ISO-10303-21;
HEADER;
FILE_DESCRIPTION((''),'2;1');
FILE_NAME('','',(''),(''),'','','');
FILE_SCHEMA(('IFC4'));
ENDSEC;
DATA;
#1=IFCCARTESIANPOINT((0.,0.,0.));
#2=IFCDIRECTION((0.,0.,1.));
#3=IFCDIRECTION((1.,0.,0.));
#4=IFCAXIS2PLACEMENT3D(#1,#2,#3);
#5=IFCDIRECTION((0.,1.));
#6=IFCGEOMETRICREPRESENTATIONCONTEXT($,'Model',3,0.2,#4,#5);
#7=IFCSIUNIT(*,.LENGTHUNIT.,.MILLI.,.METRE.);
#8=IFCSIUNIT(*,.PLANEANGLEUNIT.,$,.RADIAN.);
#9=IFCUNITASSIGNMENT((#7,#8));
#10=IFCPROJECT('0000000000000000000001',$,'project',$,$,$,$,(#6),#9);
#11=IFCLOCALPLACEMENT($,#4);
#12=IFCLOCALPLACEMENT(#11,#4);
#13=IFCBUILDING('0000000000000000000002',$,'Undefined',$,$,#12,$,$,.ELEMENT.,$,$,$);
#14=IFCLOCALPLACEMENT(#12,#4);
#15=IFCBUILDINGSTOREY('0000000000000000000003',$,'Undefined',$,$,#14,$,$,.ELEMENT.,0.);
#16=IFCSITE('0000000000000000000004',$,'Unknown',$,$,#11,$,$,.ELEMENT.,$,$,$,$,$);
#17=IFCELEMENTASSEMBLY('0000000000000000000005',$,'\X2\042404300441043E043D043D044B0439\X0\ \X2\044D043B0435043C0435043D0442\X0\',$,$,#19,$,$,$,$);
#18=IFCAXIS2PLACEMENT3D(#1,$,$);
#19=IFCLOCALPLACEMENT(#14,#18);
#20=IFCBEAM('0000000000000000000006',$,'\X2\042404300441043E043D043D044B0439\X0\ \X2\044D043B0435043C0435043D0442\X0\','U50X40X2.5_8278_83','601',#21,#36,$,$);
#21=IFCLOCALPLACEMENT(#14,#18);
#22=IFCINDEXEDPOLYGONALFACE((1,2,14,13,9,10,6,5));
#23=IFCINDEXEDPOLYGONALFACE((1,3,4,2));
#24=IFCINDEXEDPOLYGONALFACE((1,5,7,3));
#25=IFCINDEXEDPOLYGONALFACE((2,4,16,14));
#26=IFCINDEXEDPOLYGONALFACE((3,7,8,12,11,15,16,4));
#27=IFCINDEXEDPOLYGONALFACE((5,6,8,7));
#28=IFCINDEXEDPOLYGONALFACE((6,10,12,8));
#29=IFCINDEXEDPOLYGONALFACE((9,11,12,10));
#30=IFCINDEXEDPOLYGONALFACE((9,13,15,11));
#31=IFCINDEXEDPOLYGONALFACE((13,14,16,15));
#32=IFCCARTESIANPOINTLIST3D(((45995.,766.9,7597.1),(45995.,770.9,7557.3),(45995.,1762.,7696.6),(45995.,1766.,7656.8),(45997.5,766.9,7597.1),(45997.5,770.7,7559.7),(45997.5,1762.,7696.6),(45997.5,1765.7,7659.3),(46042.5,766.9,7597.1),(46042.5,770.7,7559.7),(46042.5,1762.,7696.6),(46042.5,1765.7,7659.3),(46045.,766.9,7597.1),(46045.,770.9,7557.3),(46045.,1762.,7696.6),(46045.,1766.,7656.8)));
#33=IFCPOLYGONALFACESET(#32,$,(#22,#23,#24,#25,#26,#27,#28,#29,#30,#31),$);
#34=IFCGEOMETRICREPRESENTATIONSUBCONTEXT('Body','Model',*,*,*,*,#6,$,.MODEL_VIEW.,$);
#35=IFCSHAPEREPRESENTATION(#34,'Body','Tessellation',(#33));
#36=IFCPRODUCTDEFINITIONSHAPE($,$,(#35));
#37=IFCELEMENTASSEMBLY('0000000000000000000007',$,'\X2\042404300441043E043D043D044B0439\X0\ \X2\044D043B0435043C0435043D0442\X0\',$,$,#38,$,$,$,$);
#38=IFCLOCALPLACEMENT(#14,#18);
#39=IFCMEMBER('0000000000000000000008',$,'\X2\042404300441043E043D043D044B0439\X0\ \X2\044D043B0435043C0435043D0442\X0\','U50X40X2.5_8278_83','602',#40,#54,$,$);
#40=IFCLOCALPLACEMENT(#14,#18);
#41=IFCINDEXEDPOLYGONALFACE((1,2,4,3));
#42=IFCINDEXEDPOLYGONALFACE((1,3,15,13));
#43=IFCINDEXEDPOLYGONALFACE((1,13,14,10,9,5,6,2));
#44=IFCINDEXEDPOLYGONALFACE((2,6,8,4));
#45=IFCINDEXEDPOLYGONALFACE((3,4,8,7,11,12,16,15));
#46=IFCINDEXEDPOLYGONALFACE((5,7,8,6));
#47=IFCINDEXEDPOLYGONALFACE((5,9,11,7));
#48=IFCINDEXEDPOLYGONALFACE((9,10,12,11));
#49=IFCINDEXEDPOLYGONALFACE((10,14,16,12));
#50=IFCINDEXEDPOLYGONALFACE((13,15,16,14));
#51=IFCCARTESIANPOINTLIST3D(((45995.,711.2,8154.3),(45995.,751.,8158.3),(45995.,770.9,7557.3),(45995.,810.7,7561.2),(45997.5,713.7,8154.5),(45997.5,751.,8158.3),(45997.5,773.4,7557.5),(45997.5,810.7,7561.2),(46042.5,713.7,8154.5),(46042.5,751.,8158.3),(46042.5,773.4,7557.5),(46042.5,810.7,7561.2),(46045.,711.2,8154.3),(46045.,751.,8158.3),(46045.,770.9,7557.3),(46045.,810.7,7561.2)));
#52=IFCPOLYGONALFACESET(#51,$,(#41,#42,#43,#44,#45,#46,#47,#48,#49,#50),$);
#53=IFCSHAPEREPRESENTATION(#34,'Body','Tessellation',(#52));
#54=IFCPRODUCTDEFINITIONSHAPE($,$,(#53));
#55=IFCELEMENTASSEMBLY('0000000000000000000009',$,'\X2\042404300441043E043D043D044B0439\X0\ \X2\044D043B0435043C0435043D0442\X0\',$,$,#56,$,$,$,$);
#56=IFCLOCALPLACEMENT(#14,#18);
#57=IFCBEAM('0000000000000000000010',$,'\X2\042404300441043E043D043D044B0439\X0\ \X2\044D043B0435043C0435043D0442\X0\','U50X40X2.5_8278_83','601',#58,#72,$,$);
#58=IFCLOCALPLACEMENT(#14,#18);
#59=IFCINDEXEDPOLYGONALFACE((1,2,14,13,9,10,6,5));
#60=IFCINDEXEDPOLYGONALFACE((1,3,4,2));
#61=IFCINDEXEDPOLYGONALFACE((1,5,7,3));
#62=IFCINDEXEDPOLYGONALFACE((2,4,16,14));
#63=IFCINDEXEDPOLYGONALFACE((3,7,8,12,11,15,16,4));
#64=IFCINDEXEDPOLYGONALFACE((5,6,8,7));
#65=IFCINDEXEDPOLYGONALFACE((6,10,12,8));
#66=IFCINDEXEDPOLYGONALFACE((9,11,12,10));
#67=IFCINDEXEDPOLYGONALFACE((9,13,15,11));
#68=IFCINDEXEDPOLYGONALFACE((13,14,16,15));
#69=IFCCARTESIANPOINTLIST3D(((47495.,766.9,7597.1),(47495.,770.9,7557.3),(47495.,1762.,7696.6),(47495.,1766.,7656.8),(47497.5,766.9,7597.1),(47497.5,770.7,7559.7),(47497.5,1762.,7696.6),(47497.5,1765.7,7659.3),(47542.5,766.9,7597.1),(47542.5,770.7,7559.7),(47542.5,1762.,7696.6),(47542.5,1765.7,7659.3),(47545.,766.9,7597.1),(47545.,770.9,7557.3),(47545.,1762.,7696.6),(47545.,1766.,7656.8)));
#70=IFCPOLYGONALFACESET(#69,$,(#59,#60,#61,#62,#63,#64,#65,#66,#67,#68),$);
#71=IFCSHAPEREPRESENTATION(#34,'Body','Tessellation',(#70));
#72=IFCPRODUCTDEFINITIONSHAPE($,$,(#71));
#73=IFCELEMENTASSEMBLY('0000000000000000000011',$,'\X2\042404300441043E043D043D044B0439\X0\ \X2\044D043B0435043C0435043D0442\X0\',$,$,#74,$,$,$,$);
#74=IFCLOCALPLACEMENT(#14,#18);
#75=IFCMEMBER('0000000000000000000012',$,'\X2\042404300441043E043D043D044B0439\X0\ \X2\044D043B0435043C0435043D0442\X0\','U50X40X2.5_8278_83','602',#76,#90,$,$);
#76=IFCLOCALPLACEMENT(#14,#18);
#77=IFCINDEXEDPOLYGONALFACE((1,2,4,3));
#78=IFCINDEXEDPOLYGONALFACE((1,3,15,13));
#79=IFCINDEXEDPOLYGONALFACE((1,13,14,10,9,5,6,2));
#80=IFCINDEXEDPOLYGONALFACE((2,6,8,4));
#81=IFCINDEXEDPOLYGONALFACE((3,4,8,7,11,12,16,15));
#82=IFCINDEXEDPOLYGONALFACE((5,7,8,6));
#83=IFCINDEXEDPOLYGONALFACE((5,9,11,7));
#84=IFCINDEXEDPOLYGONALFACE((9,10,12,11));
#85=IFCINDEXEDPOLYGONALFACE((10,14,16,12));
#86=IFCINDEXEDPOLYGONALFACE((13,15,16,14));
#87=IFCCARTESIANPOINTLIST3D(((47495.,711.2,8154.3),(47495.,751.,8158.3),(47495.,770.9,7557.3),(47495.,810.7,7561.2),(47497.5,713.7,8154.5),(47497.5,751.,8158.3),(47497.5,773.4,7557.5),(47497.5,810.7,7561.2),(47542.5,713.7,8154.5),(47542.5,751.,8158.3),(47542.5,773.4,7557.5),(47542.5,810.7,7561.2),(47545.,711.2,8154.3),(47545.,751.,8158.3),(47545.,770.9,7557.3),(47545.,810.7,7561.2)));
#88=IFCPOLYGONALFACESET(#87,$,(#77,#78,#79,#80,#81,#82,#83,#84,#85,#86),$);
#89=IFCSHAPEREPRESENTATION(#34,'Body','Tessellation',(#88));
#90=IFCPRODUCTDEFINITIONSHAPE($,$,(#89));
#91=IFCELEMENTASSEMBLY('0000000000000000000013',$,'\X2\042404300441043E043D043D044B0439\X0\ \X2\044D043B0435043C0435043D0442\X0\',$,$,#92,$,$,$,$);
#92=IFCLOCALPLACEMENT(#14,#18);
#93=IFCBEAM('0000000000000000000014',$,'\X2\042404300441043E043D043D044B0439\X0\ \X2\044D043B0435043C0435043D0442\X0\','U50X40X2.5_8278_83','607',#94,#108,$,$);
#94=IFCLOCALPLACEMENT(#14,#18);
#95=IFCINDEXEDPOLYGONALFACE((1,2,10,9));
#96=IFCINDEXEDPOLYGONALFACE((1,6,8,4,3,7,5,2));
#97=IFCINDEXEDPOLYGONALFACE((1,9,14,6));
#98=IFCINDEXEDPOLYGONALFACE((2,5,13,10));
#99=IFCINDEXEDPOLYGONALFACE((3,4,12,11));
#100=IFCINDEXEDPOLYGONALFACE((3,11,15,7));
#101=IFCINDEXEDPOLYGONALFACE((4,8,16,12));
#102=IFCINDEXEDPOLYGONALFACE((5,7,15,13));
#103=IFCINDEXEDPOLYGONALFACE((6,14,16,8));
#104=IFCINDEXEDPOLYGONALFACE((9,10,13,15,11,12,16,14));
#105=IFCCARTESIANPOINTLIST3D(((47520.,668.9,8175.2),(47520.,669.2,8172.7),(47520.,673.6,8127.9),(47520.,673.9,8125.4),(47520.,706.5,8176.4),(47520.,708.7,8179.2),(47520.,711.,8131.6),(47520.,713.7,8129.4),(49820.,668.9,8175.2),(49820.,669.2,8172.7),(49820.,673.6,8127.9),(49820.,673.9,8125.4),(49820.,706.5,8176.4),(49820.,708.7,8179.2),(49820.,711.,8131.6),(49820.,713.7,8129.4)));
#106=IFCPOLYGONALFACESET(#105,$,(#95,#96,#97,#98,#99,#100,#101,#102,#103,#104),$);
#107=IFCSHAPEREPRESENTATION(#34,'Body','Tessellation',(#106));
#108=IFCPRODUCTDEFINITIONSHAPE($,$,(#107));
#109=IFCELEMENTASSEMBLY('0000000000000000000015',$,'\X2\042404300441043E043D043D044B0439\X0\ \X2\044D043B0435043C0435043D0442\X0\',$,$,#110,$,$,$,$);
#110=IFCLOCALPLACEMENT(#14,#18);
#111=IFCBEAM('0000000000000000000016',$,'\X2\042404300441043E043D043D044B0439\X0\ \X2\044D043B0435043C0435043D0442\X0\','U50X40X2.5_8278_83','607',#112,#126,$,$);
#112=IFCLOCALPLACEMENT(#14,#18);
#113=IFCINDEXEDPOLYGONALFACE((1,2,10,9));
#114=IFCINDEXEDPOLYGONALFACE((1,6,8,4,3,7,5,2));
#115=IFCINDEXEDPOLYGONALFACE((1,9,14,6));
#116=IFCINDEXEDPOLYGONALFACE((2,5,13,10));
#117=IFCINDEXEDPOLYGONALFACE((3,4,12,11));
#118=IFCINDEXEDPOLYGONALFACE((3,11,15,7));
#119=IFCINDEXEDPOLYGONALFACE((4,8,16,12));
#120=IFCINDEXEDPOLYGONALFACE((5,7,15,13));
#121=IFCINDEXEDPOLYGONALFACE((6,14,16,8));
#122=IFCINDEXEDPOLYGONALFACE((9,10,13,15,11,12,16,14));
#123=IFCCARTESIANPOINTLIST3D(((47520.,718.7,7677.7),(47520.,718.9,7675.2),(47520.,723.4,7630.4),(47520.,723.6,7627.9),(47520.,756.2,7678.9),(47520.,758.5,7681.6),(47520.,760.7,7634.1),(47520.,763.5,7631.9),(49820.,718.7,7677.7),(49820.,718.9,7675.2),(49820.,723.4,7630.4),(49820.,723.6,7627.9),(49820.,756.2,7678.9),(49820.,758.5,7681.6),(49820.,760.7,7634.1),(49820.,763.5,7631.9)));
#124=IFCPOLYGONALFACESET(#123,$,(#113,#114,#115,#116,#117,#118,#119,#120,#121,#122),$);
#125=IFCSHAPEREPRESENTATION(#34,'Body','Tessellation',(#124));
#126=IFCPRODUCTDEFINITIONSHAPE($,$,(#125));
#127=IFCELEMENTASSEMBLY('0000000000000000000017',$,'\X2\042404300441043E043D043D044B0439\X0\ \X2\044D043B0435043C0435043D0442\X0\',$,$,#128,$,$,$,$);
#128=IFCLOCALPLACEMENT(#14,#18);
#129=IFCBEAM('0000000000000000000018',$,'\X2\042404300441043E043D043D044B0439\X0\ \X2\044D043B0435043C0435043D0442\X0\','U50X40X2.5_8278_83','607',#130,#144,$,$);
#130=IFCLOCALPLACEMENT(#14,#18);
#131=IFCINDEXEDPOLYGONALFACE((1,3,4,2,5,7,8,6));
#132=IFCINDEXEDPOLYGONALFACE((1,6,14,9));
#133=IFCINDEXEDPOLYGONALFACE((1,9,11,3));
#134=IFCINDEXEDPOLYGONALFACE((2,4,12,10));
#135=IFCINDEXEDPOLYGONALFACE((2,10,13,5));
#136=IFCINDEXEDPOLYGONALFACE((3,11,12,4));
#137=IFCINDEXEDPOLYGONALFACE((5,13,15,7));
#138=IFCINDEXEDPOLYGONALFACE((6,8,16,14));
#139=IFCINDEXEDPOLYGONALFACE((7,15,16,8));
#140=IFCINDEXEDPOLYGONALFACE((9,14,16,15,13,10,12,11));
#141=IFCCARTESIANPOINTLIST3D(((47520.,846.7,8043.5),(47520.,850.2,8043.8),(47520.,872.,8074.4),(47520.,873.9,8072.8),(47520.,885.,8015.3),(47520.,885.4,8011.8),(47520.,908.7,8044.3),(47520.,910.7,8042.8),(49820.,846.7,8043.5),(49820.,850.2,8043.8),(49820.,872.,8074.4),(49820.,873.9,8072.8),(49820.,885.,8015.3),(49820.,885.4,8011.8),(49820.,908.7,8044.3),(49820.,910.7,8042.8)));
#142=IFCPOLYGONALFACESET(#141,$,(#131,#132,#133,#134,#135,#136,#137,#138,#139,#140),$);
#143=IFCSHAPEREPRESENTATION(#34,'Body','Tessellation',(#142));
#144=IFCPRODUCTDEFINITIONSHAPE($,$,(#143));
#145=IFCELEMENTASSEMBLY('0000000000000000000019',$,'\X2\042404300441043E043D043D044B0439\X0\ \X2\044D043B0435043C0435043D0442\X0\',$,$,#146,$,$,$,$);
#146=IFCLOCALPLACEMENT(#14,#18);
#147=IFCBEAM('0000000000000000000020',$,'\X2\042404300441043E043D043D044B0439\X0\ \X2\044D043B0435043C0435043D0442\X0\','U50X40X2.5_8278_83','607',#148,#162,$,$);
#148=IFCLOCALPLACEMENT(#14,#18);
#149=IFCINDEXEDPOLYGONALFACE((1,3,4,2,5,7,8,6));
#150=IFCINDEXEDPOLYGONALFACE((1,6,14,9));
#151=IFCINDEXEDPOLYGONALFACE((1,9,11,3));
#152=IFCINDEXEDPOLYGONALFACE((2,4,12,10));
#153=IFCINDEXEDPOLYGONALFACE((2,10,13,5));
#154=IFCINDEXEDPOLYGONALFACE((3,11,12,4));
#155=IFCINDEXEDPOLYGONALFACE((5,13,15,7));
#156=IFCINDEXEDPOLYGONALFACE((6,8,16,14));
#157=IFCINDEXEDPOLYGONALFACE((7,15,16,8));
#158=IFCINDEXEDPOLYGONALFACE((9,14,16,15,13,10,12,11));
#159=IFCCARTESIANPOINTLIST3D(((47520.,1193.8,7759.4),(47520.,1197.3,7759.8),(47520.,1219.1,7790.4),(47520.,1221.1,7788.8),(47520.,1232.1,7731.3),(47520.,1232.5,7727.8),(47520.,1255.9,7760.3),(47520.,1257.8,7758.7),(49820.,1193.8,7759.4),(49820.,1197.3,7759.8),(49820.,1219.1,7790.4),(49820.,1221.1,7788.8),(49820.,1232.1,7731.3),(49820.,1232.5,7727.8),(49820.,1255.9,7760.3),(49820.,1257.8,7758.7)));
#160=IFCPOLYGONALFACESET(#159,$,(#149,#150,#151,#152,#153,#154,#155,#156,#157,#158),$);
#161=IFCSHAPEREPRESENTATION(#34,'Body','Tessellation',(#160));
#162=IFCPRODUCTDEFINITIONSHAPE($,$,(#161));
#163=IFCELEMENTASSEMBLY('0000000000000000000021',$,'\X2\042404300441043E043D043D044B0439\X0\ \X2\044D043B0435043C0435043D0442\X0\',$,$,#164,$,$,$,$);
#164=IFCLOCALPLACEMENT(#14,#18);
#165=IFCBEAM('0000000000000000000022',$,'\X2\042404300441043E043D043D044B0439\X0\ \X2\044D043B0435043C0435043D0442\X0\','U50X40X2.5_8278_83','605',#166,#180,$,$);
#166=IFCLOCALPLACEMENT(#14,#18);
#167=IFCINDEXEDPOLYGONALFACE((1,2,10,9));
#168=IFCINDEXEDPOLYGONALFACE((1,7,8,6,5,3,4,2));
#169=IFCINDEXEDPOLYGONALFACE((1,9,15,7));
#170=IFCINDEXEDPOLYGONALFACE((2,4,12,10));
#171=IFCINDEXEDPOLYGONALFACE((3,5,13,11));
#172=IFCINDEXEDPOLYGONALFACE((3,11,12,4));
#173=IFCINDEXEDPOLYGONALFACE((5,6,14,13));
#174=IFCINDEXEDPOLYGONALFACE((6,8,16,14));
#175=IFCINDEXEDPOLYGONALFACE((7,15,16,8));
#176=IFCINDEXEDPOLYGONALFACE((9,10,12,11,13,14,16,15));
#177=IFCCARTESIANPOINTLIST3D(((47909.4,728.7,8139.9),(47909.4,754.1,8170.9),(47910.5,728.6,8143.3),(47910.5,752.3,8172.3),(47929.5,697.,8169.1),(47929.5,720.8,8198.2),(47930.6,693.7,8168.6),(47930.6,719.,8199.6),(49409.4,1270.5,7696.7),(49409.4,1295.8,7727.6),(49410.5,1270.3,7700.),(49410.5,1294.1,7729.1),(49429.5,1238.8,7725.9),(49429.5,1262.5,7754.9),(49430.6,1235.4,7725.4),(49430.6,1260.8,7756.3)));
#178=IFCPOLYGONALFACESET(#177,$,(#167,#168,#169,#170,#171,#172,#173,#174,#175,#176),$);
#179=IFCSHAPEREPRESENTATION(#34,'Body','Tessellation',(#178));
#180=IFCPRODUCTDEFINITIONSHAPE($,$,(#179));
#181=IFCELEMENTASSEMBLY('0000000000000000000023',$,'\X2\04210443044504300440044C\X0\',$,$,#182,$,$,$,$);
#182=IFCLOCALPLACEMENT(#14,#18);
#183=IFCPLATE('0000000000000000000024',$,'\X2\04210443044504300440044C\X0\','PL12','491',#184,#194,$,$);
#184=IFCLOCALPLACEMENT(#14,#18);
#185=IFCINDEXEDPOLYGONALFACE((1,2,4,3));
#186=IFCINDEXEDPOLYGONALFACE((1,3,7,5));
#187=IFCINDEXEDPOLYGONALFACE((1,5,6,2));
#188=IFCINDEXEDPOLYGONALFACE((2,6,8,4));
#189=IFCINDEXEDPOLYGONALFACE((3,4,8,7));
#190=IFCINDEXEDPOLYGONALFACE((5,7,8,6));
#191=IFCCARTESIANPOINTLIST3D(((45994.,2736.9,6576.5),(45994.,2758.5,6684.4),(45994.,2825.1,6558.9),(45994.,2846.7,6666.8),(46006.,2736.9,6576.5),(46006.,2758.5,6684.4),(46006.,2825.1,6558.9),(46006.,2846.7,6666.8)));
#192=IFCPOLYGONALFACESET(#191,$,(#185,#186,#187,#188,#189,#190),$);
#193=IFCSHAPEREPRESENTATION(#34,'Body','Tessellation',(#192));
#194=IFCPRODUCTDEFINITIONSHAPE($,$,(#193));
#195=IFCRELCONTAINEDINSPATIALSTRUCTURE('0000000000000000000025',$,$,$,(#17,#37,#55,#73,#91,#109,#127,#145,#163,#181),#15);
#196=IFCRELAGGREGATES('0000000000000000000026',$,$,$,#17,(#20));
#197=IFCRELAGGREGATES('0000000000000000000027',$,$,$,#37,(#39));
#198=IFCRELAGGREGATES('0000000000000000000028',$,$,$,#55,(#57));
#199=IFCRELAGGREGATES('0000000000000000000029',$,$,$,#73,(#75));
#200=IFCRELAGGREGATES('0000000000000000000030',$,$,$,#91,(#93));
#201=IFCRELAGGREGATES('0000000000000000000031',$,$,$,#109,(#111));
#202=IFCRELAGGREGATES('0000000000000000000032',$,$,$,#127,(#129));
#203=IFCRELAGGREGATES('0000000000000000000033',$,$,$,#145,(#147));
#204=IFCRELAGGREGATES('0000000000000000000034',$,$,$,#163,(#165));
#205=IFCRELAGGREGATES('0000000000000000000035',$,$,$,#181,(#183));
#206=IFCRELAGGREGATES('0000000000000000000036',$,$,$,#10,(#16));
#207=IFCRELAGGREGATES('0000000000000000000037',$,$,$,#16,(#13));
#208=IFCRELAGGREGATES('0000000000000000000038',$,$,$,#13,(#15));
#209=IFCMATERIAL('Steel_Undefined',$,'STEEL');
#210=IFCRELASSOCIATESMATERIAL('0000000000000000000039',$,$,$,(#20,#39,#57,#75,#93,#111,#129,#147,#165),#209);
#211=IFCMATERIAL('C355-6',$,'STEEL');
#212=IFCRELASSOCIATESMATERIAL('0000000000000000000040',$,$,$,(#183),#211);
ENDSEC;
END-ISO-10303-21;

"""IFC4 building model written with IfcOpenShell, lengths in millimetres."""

from ifc_helpers import new_model, si_unit, direction, frame, origin_with_axes, place, context, subcontext, project, spatial, line, indexed_curve, outline, extrude, material, element, aggregate, save


model = new_model("IFC4")

# Units and contexts
model_context = context("Model", 3, precision=0.2, world=origin_with_axes(), true_north=direction((0.0, 1.0)))
body_context = subcontext(model_context, "Body", "Model", "MODEL_VIEW")
ifc_project = project(units=[si_unit("LENGTHUNIT", "METRE", prefix="MILLI"), si_unit("PLANEANGLEUNIT", "RADIAN")], contexts=[model_context])

# Site, building, storey
site_placement = place(None, origin_with_axes())
site = spatial("IfcSite", under=ifc_project, at=site_placement, Name="Unknown", CompositionType="ELEMENT")
building_placement = place(site_placement, origin_with_axes())
building = spatial("IfcBuilding", under=site, at=building_placement, Name="Undefined", CompositionType="ELEMENT")
storey_placement = place(building_placement, origin_with_axes())
storey = spatial("IfcBuildingStorey", under=building, at=storey_placement, Name="Undefined", CompositionType="ELEMENT", Elevation=0.0)

# Element assembly, beam
assembly_1_placement = place(storey_placement, frame((46020.0, 768.9, 7577.2), z_axis=(0.0, -0.099504, 0.995037), x_axis=(0.0, 0.995037, 0.099504)))
assembly_1 = element("IfcElementAssembly", 1, at=assembly_1_placement, inside=storey, Name="Фасонный элемент")
ifc_material_1 = material(Name="Steel_Undefined", Category="STEEL")
beam_1_placement = place(assembly_1_placement, origin_with_axes())
beam_1 = element("IfcBeam", 2, at=beam_1_placement, material=ifc_material_1, Name="Фасонный элемент", Description="U50X40X2.5_8278_83", ObjectType="601", context=body_context, shape_type="SolidModel", body=[
    extrude(outline(indexed_curve([(-20.0, -25.0), (20.0, -25.0), (20.0, -22.5), (-17.5, -22.5), (-17.5, 22.5), (20.0, 22.5), (20.0, 25.0), (-20.0, 25.0)], segments=[line(1, 2, 3, 4, 5, 6, 7, 8, 1)])), frame((0.0, 0.0, 0.0), z_axis=(-1.0, 0.0, 0.0), x_axis=(0.0, 0.0, 1.0)), (0.0, 0.0, -1.0), 1000.0),
])
aggregate(assembly_1, [beam_1])

# Element assembly, member
assembly_2_placement = place(storey_placement, frame((46020.0, 790.8, 7559.3), z_axis=(0.0, 0.995037, 0.099504), x_axis=(0.0, -0.099504, 0.995037)))
assembly_2 = element("IfcElementAssembly", 3, at=assembly_2_placement, inside=storey, Name="Фасонный элемент")
member_1_placement = place(assembly_2_placement, origin_with_axes())
member_1 = element("IfcMember", 4, at=member_1_placement, material=ifc_material_1, Name="Фасонный элемент", Description="U50X40X2.5_8278_83", ObjectType="602", context=body_context, shape_type="SolidModel", body=[
    extrude(outline(indexed_curve([(-20.0, -25.0), (20.0, -25.0), (20.0, -22.5), (-17.5, -22.5), (-17.5, 22.5), (20.0, 22.5), (20.0, 25.0), (-20.0, 25.0)], segments=[line(1, 2, 3, 4, 5, 6, 7, 8, 1)])), frame((0.0, 0.0, 0.0), z_axis=(-1.0, 0.0, 0.0), x_axis=(0.0, 0.0, 1.0)), (0.0, 0.0, -1.0), 600.0),
])
aggregate(assembly_2, [member_1])

# Element assembly, beam
assembly_3_placement = place(storey_placement, frame((47520.0, 768.9, 7577.2), z_axis=(0.0, -0.099504, 0.995037), x_axis=(0.0, 0.995037, 0.099504)))
assembly_3 = element("IfcElementAssembly", 5, at=assembly_3_placement, inside=storey, Name="Фасонный элемент")
beam_2_placement = place(assembly_3_placement, origin_with_axes())
beam_2 = element("IfcBeam", 6, at=beam_2_placement, material=ifc_material_1, Name="Фасонный элемент", Description="U50X40X2.5_8278_83", ObjectType="601", context=body_context, shape_type="SolidModel", body=[
    extrude(outline(indexed_curve([(-20.0, -25.0), (20.0, -25.0), (20.0, -22.5), (-17.5, -22.5), (-17.5, 22.5), (20.0, 22.5), (20.0, 25.0), (-20.0, 25.0)], segments=[line(1, 2, 3, 4, 5, 6, 7, 8, 1)])), frame((0.0, 0.0, 0.0), z_axis=(-1.0, 0.0, 0.0), x_axis=(0.0, 0.0, 1.0)), (0.0, 0.0, -1.0), 1000.0),
])
aggregate(assembly_3, [beam_2])

# Element assembly, member
assembly_4_placement = place(storey_placement, frame((47520.0, 790.8, 7559.3), z_axis=(0.0, 0.995037, 0.099504), x_axis=(0.0, -0.099504, 0.995037)))
assembly_4 = element("IfcElementAssembly", 7, at=assembly_4_placement, inside=storey, Name="Фасонный элемент")
member_2_placement = place(assembly_4_placement, origin_with_axes())
member_2 = element("IfcMember", 8, at=member_2_placement, material=ifc_material_1, Name="Фасонный элемент", Description="U50X40X2.5_8278_83", ObjectType="602", context=body_context, shape_type="SolidModel", body=[
    extrude(outline(indexed_curve([(-20.0, -25.0), (20.0, -25.0), (20.0, -22.5), (-17.5, -22.5), (-17.5, 22.5), (20.0, 22.5), (20.0, 25.0), (-20.0, 25.0)], segments=[line(1, 2, 3, 4, 5, 6, 7, 8, 1)])), frame((0.0, 0.0, 0.0), z_axis=(-1.0, 0.0, 0.0), x_axis=(0.0, 0.0, 1.0)), (0.0, 0.0, -1.0), 600.0),
])
aggregate(assembly_4, [member_2])

# Element assemblies, beams
assembly_5_placement = place(storey_placement, frame((47520.0, 691.3, 8152.3), z_axis=(0.0, -0.995037, -0.099504), x_axis=(1.0, 0.0, 0.0)))
assembly_5 = element("IfcElementAssembly", 9, at=assembly_5_placement, inside=storey, Name="Фасонный элемент")
beam_3_placement = place(assembly_5_placement, origin_with_axes())
beam_3 = element("IfcBeam", 10, at=beam_3_placement, material=ifc_material_1, Name="Фасонный элемент", Description="U50X40X2.5_8278_83", ObjectType="607", context=body_context, shape_type="SolidModel", body=[
    extrude(outline(indexed_curve([(-20.0, -25.0), (20.0, -25.0), (20.0, -22.5), (-17.5, -22.5), (-17.5, 22.5), (20.0, 22.5), (20.0, 25.0), (-20.0, 25.0)], segments=[line(1, 2, 3, 4, 5, 6, 7, 8, 1)])), frame((0.0, 0.0, 0.0), z_axis=(-1.0, 0.0, 0.0), x_axis=(0.0, 0.0, 1.0)), (0.0, 0.0, -1.0), 2300.0),
])
aggregate(assembly_5, [beam_3])
assembly_6_placement = place(storey_placement, frame((47520.0, 741.1, 7654.8), z_axis=(0.0, -0.995037, -0.099504), x_axis=(1.0, 0.0, 0.0)))
assembly_6 = element("IfcElementAssembly", 11, at=assembly_6_placement, inside=storey, Name="Фасонный элемент")
beam_4_placement = place(assembly_6_placement, origin_with_axes())
beam_4 = element("IfcBeam", 12, at=beam_4_placement, material=ifc_material_1, Name="Фасонный элемент", Description="U50X40X2.5_8278_83", ObjectType="607", context=body_context, shape_type="SolidModel", body=[
    extrude(outline(indexed_curve([(-20.0, -25.0), (20.0, -25.0), (20.0, -22.5), (-17.5, -22.5), (-17.5, 22.5), (20.0, 22.5), (20.0, 25.0), (-20.0, 25.0)], segments=[line(1, 2, 3, 4, 5, 6, 7, 8, 1)])), frame((0.0, 0.0, 0.0), z_axis=(-1.0, 0.0, 0.0), x_axis=(0.0, 0.0, 1.0)), (0.0, 0.0, -1.0), 2300.0),
])
aggregate(assembly_6, [beam_4])
assembly_7_placement = place(storey_placement, frame((47520.0, 878.7, 8043.1), z_axis=(0.0, 0.633238, 0.773957), x_axis=(1.0, 0.0, 0.0)))
assembly_7 = element("IfcElementAssembly", 13, at=assembly_7_placement, inside=storey, Name="Фасонный элемент")
beam_5_placement = place(assembly_7_placement, origin_with_axes())
beam_5 = element("IfcBeam", 14, at=beam_5_placement, material=ifc_material_1, Name="Фасонный элемент", Description="U50X40X2.5_8278_83", ObjectType="607", context=body_context, shape_type="SolidModel", body=[
    extrude(outline(indexed_curve([(-20.0, -25.0), (20.0, -25.0), (20.0, -22.5), (-17.5, -22.5), (-17.5, 22.5), (20.0, 22.5), (20.0, 25.0), (-20.0, 25.0)], segments=[line(1, 2, 3, 4, 5, 6, 7, 8, 1)])), frame((0.0, 0.0, 0.0), z_axis=(-1.0, 0.0, 0.0), x_axis=(0.0, 0.0, 1.0)), (0.0, 0.0, -1.0), 2300.0),
])
aggregate(assembly_7, [beam_5])
assembly_8_placement = place(storey_placement, frame((47520.0, 1225.8, 7759.1), z_axis=(0.0, 0.633238, 0.773957), x_axis=(1.0, 0.0, 0.0)))
assembly_8 = element("IfcElementAssembly", 15, at=assembly_8_placement, inside=storey, Name="Фасонный элемент")
beam_6_placement = place(assembly_8_placement, origin_with_axes())
beam_6 = element("IfcBeam", 16, at=beam_6_placement, material=ifc_material_1, Name="Фасонный элемент", Description="U50X40X2.5_8278_83", ObjectType="607", context=body_context, shape_type="SolidModel", body=[
    extrude(outline(indexed_curve([(-20.0, -25.0), (20.0, -25.0), (20.0, -22.5), (-17.5, -22.5), (-17.5, 22.5), (20.0, 22.5), (20.0, 25.0), (-20.0, 25.0)], segments=[line(1, 2, 3, 4, 5, 6, 7, 8, 1)])), frame((0.0, 0.0, 0.0), z_axis=(-1.0, 0.0, 0.0), x_axis=(0.0, 0.0, 1.0)), (0.0, 0.0, -1.0), 2300.0),
])
aggregate(assembly_8, [beam_6])
assembly_9_placement = place(storey_placement, frame((47920.0, 723.9, 8169.8), z_axis=(0.0, 0.633238, 0.773957), x_axis=(0.906183, 0.327295, -0.267787)))
assembly_9 = element("IfcElementAssembly", 17, at=assembly_9_placement, inside=storey, Name="Фасонный элемент")
beam_7_placement = place(assembly_9_placement, origin_with_axes())
beam_7 = element("IfcBeam", 18, at=beam_7_placement, material=ifc_material_1, Name="Фасонный элемент", Description="U50X40X2.5_8278_83", ObjectType="605", context=body_context, shape_type="SolidModel", body=[
    extrude(outline(indexed_curve([(-20.0, -25.0), (20.0, -25.0), (20.0, -22.5), (-17.5, -22.5), (-17.5, 22.5), (20.0, 22.5), (20.0, 25.0), (-20.0, 25.0)], segments=[line(1, 2, 3, 4, 5, 6, 7, 8, 1)])), frame((0.0, 0.0, 0.0), z_axis=(-1.0, 0.0, 0.0), x_axis=(0.0, 0.0, 1.0)), (0.0, 0.0, -1.0), 1655.3),
])
aggregate(assembly_9, [beam_7])

# Shared definitions
ifc_material_2 = material(Name="C355-6", Category="STEEL")

# Element assembly, plate
assembly_10_placement = place(storey_placement, frame((46000.0, 2758.5, 6684.4), z_axis=(-1.0, 0.0, 0.0), x_axis=(0.0, 0.980581, -0.196116)))
assembly_10 = element("IfcElementAssembly", 19, at=assembly_10_placement, inside=storey, Name="Сухарь")
plate_1_placement = place(assembly_10_placement, origin_with_axes())
plate_1 = element("IfcPlate", 20, at=plate_1_placement, material=ifc_material_2, Name="Сухарь", Description="PL12", ObjectType="491", context=body_context, shape_type="SolidModel", body=[
    extrude(outline(indexed_curve([(0.0, 0.0), (90.0, 0.0), (90.0, 110.0), (0.0, 110.0)], segments=[line(1, 2, 3, 4, 1)])), frame((0.0, 0.0, 6.0), z_axis=(0.0, 0.0, 1.0), x_axis=(1.0, 0.0, 0.0)), (0.0, 0.0, -1.0), 12.0),
])
aggregate(assembly_10, [plate_1])

save(model, "model.ifc")
